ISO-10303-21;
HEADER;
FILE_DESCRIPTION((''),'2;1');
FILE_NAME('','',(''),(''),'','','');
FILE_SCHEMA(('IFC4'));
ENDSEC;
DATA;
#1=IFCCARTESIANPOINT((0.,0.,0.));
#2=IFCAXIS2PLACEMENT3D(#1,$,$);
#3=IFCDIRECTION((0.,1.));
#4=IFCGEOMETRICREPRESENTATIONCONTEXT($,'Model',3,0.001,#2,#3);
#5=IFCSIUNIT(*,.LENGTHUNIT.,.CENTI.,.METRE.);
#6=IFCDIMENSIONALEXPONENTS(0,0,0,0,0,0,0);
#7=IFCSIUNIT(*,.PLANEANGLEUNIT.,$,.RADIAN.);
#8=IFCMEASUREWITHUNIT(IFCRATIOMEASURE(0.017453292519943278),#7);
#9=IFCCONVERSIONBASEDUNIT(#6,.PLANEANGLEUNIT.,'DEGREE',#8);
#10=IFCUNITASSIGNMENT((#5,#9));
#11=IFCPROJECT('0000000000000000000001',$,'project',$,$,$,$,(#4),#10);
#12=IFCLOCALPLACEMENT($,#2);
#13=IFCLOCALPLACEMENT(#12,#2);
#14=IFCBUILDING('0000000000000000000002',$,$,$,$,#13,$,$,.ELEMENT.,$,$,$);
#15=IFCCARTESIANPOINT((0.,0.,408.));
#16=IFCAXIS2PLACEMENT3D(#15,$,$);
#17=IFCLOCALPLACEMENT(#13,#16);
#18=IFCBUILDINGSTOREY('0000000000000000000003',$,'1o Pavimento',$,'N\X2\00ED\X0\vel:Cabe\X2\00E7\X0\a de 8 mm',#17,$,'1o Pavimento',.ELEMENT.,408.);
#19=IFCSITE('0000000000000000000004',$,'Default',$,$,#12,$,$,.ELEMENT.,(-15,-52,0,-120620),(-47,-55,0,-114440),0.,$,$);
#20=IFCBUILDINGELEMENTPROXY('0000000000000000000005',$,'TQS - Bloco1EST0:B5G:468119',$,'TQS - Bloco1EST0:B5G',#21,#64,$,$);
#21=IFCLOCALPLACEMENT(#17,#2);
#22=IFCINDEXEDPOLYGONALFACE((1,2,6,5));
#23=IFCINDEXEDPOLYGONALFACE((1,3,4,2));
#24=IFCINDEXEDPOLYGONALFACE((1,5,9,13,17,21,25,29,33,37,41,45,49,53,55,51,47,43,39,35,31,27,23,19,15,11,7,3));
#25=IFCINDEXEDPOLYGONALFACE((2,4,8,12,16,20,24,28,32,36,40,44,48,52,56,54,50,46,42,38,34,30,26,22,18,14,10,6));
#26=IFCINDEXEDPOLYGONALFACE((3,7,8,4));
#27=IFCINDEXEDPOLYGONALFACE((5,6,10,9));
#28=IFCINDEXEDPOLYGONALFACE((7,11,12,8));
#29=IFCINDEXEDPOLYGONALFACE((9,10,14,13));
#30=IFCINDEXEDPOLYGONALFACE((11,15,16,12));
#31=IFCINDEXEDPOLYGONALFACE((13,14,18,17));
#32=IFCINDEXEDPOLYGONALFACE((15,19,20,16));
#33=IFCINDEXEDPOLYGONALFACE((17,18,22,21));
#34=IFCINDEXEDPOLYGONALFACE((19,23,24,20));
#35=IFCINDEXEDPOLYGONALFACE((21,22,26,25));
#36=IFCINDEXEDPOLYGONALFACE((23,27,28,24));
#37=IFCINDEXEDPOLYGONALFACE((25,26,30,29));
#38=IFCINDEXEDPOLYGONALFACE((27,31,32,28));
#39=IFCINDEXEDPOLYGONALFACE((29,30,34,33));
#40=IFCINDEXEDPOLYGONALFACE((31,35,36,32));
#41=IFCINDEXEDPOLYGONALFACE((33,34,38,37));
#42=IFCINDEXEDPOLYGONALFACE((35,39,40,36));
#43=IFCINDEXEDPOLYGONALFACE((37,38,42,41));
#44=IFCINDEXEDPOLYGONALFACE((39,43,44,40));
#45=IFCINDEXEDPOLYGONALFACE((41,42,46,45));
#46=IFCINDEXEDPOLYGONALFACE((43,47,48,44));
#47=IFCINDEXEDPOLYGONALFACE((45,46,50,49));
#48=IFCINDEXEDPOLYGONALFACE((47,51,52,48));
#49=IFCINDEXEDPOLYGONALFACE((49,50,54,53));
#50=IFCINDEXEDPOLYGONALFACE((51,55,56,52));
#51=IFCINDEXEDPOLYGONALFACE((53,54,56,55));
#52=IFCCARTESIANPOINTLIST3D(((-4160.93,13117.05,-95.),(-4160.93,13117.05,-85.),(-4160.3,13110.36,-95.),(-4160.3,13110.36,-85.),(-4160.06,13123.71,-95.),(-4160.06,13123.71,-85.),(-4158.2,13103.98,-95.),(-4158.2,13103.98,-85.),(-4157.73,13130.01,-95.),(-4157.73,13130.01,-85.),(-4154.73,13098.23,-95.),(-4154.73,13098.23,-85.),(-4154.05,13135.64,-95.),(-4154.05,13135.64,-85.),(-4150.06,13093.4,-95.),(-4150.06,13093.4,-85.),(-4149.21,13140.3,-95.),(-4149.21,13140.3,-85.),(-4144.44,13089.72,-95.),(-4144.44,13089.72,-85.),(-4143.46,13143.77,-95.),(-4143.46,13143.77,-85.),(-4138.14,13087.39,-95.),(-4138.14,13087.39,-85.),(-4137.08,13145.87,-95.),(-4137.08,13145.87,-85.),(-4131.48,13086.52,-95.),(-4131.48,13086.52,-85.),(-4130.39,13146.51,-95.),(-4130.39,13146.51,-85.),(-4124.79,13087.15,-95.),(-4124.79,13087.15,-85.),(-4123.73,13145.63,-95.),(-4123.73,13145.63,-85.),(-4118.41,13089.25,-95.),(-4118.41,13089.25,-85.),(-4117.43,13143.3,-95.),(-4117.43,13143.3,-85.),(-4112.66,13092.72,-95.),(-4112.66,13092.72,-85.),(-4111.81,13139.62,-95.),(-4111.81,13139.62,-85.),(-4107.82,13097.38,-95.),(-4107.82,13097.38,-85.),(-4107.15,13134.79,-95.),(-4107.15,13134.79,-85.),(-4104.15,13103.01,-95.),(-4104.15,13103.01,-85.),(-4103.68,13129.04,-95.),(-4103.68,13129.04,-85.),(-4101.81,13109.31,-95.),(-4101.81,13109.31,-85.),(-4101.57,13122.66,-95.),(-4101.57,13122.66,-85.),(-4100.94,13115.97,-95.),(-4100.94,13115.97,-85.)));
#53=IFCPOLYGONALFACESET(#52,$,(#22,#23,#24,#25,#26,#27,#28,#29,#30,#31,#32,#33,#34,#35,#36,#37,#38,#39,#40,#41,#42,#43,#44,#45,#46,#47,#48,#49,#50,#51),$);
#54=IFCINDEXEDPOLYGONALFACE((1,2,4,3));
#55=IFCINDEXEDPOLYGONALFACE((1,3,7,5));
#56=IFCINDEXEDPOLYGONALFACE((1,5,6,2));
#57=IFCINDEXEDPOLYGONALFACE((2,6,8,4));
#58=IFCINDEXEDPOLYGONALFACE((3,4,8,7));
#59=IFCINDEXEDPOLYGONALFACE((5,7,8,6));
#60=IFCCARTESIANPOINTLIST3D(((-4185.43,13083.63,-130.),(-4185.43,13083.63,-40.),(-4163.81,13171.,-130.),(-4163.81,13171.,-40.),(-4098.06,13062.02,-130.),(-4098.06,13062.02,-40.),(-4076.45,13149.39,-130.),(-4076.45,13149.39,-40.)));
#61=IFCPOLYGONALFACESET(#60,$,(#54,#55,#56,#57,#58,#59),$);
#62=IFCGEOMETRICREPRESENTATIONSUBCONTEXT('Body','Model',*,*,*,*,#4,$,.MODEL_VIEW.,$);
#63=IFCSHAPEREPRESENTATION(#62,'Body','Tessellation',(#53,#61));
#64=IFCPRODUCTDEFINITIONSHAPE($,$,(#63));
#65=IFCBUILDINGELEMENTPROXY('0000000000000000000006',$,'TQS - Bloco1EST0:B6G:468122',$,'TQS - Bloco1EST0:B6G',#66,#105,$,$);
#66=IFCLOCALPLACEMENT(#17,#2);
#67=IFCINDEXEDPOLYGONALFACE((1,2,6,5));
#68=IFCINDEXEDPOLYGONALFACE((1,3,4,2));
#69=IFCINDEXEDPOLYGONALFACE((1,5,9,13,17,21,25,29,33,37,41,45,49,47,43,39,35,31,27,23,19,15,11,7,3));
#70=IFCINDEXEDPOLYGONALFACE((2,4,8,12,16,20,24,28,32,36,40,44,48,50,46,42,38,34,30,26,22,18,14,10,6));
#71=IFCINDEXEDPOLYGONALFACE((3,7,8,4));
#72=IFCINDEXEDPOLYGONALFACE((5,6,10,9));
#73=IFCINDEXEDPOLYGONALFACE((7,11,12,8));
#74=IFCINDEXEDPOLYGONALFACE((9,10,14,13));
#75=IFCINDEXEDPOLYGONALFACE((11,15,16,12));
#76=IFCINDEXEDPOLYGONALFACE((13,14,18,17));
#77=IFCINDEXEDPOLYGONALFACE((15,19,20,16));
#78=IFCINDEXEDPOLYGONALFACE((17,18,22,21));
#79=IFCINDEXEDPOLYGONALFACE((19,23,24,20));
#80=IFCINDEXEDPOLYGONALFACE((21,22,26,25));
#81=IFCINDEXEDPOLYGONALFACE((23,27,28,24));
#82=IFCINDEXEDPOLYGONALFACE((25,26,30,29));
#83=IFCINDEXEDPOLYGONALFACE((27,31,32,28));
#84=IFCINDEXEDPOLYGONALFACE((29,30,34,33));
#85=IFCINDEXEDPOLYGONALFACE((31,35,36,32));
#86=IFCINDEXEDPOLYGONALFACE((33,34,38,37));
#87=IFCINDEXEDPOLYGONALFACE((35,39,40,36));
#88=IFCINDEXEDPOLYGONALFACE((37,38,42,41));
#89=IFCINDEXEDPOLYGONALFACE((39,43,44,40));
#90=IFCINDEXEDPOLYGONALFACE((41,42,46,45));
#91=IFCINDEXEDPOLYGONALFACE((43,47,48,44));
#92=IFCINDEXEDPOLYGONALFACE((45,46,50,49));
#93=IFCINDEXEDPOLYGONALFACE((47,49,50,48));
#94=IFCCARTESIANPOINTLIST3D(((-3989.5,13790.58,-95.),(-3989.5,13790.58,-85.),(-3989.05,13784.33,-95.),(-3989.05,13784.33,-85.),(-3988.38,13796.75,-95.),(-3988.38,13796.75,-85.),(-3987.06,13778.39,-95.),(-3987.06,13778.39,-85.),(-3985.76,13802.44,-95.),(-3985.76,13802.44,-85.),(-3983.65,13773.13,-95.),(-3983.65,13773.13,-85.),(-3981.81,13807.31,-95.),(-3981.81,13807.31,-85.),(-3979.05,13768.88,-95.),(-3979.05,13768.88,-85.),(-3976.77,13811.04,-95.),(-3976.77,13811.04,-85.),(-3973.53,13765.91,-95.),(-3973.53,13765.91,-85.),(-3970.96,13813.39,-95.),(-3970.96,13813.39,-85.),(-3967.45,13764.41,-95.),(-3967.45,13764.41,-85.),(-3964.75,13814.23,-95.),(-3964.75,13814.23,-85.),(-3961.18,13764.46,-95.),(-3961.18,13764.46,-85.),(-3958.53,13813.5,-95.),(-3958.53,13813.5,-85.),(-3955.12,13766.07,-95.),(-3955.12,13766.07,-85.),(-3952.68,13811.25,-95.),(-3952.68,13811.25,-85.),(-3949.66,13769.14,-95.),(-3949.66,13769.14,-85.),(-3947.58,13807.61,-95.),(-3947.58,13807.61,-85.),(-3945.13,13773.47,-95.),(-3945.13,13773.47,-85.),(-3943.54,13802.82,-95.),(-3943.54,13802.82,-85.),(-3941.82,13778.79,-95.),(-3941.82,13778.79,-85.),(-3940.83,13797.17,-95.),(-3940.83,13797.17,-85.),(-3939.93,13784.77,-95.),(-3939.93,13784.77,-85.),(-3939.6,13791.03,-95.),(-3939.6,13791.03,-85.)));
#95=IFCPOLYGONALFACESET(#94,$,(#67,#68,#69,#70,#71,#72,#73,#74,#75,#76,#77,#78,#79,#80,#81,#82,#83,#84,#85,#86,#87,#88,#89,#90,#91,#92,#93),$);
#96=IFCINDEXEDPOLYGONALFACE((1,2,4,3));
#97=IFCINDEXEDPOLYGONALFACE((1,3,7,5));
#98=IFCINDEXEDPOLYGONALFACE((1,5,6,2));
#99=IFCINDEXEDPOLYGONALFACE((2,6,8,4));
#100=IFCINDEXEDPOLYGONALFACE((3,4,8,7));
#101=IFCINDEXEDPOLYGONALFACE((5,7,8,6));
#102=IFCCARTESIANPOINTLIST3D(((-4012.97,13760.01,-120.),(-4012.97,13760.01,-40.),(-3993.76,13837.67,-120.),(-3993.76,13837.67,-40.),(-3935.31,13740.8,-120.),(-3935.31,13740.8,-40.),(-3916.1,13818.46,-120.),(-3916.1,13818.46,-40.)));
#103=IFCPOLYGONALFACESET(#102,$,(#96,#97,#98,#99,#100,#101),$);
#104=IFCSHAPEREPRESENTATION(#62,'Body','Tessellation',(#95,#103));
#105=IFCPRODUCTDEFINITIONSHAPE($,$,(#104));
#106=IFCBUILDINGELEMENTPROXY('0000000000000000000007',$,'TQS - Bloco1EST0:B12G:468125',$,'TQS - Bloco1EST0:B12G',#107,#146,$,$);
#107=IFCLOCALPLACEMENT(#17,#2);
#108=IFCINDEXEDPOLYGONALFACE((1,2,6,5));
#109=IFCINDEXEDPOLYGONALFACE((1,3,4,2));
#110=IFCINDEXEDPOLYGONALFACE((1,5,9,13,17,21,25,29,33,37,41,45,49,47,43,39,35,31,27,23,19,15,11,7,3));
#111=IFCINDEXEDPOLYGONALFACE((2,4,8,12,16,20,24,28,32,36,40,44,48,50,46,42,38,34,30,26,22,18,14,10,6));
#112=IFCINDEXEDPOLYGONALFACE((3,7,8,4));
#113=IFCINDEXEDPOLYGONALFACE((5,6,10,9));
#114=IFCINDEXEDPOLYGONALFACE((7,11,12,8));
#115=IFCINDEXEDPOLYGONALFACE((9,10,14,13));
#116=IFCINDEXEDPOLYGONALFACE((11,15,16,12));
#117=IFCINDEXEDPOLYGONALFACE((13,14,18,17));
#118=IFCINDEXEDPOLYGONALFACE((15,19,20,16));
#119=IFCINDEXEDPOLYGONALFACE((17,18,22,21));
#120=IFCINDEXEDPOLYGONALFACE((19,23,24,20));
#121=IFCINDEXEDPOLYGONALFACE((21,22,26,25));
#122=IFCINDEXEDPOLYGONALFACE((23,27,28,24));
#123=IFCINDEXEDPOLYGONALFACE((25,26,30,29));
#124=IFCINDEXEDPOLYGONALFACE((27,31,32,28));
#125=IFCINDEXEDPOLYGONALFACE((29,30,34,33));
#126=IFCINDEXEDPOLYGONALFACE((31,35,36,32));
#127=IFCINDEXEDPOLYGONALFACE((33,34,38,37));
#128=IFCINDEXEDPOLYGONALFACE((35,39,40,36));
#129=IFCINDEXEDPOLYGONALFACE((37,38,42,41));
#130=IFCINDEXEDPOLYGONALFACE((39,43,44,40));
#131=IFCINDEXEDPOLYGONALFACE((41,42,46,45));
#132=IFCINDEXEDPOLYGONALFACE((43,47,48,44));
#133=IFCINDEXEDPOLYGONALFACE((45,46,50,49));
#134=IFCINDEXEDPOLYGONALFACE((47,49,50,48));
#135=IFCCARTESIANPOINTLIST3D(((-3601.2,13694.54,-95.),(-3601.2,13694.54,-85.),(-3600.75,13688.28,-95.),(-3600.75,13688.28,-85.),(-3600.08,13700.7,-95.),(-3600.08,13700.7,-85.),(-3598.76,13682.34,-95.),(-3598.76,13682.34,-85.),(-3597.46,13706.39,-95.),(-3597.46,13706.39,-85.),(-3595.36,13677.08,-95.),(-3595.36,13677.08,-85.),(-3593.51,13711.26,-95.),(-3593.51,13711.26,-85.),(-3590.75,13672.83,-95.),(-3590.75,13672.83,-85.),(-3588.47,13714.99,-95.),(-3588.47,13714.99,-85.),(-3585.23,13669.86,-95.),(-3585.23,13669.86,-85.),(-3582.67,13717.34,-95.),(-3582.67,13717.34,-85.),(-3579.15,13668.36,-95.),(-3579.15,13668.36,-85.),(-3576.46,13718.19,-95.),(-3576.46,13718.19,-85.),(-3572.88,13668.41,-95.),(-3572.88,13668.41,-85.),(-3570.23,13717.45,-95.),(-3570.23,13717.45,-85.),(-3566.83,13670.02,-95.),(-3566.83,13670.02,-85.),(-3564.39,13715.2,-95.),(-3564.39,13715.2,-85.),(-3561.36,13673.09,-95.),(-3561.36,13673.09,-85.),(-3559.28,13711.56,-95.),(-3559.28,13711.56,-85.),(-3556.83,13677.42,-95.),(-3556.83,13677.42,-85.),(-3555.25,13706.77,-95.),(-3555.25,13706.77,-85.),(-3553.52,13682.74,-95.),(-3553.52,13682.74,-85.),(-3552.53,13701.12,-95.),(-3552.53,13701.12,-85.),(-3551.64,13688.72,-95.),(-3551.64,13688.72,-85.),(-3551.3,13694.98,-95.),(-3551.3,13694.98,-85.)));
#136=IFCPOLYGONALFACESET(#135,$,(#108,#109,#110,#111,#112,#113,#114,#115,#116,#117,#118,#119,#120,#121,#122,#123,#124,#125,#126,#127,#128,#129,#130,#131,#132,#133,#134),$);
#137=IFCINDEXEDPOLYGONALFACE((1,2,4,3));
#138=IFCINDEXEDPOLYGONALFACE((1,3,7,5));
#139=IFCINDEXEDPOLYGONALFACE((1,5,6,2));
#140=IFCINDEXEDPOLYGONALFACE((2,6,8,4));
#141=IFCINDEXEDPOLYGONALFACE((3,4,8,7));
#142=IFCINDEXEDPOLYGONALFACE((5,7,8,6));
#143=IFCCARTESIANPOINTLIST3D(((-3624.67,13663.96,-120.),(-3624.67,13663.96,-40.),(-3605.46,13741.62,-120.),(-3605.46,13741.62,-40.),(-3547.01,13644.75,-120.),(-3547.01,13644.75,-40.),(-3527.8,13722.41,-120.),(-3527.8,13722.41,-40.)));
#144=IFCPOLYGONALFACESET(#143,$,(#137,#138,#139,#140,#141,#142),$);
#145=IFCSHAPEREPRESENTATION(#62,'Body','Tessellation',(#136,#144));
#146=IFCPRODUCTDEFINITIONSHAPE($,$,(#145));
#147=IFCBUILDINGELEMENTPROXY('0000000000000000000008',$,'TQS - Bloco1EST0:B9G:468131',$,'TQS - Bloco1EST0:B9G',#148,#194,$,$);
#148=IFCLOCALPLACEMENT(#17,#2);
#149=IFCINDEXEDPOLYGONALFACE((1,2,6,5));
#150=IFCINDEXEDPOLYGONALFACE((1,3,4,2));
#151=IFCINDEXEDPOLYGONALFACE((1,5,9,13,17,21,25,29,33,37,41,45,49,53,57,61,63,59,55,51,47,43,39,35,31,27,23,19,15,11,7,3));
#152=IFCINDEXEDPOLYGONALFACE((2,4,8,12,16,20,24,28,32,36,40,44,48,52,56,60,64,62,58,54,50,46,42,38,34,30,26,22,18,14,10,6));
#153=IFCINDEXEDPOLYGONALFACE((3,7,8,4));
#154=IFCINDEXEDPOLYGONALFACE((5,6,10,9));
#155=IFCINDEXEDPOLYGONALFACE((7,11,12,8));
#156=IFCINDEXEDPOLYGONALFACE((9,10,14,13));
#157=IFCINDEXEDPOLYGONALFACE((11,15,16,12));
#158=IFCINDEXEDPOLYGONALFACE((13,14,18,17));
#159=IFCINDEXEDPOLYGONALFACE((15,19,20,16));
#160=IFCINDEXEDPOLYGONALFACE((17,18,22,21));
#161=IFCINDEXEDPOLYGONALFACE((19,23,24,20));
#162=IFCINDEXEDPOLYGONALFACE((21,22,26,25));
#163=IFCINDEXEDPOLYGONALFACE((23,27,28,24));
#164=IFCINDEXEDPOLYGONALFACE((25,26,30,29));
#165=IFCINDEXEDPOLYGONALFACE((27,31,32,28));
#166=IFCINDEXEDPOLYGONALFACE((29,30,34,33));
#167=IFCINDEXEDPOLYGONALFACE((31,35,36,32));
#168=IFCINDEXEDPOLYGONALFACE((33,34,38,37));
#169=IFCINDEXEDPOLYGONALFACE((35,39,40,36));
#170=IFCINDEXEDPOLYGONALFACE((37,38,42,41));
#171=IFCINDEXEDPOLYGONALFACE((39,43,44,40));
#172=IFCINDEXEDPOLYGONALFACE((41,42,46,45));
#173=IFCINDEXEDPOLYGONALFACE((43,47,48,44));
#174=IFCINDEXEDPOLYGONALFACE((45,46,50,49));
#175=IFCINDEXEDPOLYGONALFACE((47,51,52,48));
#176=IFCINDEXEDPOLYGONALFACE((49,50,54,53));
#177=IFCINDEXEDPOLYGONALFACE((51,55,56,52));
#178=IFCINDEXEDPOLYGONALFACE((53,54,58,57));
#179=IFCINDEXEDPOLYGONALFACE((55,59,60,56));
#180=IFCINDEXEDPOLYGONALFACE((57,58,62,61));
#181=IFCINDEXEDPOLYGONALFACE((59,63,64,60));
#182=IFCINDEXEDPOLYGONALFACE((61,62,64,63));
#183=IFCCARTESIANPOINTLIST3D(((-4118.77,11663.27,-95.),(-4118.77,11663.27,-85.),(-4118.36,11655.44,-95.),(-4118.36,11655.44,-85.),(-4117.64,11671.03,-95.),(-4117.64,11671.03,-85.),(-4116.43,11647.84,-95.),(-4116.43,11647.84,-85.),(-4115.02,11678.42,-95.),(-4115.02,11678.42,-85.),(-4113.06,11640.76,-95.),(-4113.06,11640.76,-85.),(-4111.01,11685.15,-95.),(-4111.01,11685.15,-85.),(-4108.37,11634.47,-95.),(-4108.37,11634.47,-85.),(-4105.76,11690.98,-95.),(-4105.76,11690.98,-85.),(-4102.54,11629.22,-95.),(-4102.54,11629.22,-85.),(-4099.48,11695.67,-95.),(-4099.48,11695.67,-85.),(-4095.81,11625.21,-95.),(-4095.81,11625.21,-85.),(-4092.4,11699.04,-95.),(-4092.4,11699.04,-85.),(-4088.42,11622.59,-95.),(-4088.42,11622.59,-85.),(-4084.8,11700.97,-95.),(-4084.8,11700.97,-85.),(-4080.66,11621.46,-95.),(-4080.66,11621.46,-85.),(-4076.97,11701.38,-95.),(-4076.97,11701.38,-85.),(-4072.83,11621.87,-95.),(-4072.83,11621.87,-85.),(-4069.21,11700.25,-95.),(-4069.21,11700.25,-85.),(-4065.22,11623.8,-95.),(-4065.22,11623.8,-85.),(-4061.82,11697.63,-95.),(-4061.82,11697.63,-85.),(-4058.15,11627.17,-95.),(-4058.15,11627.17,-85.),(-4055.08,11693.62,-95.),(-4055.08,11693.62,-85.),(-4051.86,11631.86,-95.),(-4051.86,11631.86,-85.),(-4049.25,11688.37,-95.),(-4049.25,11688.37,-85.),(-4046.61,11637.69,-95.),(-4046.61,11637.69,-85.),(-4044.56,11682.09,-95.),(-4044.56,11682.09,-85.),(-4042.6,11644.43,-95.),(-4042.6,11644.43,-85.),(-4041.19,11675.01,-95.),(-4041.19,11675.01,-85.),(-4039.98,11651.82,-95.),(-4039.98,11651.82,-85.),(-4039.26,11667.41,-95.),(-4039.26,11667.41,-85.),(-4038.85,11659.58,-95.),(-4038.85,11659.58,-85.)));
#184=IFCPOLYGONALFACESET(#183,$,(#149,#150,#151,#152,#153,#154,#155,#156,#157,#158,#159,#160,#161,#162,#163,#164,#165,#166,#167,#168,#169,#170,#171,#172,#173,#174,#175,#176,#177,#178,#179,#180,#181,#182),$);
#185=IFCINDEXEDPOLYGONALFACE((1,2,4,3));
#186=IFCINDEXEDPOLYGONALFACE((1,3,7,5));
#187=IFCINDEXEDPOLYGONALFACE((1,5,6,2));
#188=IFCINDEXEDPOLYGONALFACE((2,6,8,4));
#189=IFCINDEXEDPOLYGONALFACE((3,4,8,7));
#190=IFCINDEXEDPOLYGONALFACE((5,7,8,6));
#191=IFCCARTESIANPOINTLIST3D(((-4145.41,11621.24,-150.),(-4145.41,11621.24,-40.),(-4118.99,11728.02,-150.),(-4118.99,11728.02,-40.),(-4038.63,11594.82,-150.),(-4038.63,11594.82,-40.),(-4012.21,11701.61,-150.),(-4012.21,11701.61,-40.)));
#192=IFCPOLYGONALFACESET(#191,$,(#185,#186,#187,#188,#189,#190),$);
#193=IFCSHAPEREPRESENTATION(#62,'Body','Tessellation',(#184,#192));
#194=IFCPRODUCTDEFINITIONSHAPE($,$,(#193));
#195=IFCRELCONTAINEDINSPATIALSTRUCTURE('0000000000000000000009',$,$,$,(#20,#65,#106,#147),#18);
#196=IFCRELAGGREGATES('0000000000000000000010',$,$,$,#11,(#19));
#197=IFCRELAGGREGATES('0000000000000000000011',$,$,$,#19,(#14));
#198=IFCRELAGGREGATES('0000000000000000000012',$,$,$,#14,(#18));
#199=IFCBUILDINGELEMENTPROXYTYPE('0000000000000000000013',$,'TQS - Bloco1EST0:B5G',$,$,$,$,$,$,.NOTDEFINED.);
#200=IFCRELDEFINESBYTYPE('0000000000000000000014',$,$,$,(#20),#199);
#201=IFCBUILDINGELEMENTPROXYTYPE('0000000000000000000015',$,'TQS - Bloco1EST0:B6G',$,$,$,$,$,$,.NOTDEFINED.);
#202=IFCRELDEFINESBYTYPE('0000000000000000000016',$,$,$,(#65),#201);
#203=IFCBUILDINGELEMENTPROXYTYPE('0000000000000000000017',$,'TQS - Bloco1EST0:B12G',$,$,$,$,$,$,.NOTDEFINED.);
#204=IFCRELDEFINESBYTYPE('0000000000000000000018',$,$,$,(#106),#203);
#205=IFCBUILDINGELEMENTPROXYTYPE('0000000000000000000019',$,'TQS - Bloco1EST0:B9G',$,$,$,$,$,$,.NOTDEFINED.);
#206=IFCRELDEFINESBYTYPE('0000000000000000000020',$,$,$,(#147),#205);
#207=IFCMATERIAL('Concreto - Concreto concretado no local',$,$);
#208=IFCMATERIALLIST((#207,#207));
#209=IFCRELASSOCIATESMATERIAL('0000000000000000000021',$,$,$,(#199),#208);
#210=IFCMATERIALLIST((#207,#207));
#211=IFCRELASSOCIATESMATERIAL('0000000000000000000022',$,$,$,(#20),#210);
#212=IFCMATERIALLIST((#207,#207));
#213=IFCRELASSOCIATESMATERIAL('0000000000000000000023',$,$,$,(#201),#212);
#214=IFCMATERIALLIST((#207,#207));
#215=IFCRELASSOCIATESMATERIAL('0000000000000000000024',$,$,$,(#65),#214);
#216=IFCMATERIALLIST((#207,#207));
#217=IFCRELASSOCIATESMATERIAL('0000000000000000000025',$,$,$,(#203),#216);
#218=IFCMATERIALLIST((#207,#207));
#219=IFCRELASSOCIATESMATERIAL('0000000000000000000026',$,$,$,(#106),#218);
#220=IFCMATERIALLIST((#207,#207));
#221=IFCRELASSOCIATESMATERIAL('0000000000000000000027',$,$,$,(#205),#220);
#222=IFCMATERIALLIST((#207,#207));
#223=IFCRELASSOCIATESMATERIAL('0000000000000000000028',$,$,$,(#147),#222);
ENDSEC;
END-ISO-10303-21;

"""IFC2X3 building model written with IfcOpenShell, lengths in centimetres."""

from ifc_helpers import new_model, entity, si_unit, converted_unit, direction, frame, frame_2d, origin, origin_2d_with_axis, place, context, subcontext, project, spatial, rectangle, circle, extrude, source, transform, mapped, material, material_list, type_object, type_shapes, element, save


model = new_model("IFC2X3")

# Units and contexts
model_context = context("Model", 3, precision=0.001, world=origin(), true_north=direction((0.0, 1.0)))
body_context = subcontext(model_context, "Body", "Model", "MODEL_VIEW")
ifc_project = project(units=[si_unit("LENGTHUNIT", "METRE", prefix="CENTI"), converted_unit("PLANEANGLEUNIT", "DEGREE", entity("IfcRatioMeasure", 0.017453292519943278), si_unit("PLANEANGLEUNIT", "RADIAN"), dimensions=[0, 0, 0, 0, 0, 0, 0])], contexts=[model_context])

# Site, building, storey
site_placement = place(None, origin())
site = spatial("IfcSite", under=ifc_project, at=site_placement, Name="Default", CompositionType="ELEMENT", RefLatitude=(-15, -52, 0, -120620), RefLongitude=(-47, -55, 0, -114440), RefElevation=0.0)
building_placement = place(site_placement, origin())
building = spatial("IfcBuilding", under=site, at=building_placement, CompositionType="ELEMENT")
storey_placement = place(building_placement, frame((0.0, 0.0, 408.0)))
storey = spatial("IfcBuildingStorey", under=building, at=storey_placement, Name="1o Pavimento", ObjectType="Nível:Cabeça de 8 mm", LongName="1o Pavimento", CompositionType="ELEMENT", Elevation=408.0)

# Building element proxies
ifc_material_1 = material(Name="Concreto - Concreto concretado no local")
ifc_material_list_1 = material_list([ifc_material_1, ifc_material_1])
ifc_material_list_2 = material_list([ifc_material_1, ifc_material_1])
building_element_proxy_type_1 = type_object("IfcBuildingElementProxyType", Name="TQS - Bloco1EST0:B5G", PredefinedType="NOTDEFINED", material=ifc_material_list_2)
shared_shape_1 = source(origin(), body_context, "Body", "SweptSolid", [
    extrude(circle(Radius=30.0, at=frame_2d((0.0, 0.0), x_axis=(1.0, 0.0))), frame((0.0, 0.0, -55.0)), (0.0, 0.0, 1.0), 10.0),
    extrude(rectangle(XDim=90.0, YDim=90.0, at=origin_2d_with_axis()), frame((0.0, 0.0, -90.0), z_axis=(0.0, 0.0, 1.0), x_axis=(-1.0, 0.0, 0.0)), (0.0, 0.0, 1.0), 90.0),
])
type_shapes(building_element_proxy_type_1, [shared_shape_1])
proxy_1_placement = place(storey_placement, frame((-4130.94, 13116.51, -40.0), z_axis=(0.0, 0.0, 1.0), x_axis=(0.240122, 0.970743, 0.0)))
element("IfcBuildingElementProxy", 1, at=proxy_1_placement, inside=storey, type_object=building_element_proxy_type_1, material=ifc_material_list_1, Name="TQS - Bloco1EST0:B5G:468119", ObjectType="TQS - Bloco1EST0:B5G", context=body_context, shape_type="MappedRepresentation", body=[
    mapped(shared_shape_1, transform((0.0, 0.0, 0.0), scale=1.0)),
])
ifc_material_list_3 = material_list([ifc_material_1, ifc_material_1])
ifc_material_list_4 = material_list([ifc_material_1, ifc_material_1])
building_element_proxy_type_2 = type_object("IfcBuildingElementProxyType", Name="TQS - Bloco1EST0:B6G", PredefinedType="NOTDEFINED", material=ifc_material_list_4)
shared_shape_2 = source(origin(), body_context, "Body", "SweptSolid", [
    extrude(circle(Radius=25.0, at=frame_2d((0.0, 0.0), x_axis=(1.0, 0.0))), frame((0.0, 0.0, -55.0)), (0.0, 0.0, 1.0), 10.0),
    extrude(rectangle(XDim=80.0, YDim=80.0, at=origin_2d_with_axis()), frame((0.0, 0.0, -80.0), z_axis=(0.0, 0.0, 1.0), x_axis=(-1.0, 0.0, 0.0)), (0.0, 0.0, 1.0), 80.0),
])
type_shapes(building_element_proxy_type_2, [shared_shape_2])
proxy_2_placement = place(storey_placement, frame((-3964.53, 13789.23, -40.0), z_axis=(0.0, 0.0, 1.0), x_axis=(0.240122, 0.970743, 0.0)))
element("IfcBuildingElementProxy", 2, at=proxy_2_placement, inside=storey, type_object=building_element_proxy_type_2, material=ifc_material_list_3, Name="TQS - Bloco1EST0:B6G:468122", ObjectType="TQS - Bloco1EST0:B6G", context=body_context, shape_type="MappedRepresentation", body=[
    mapped(shared_shape_2, transform((0.0, 0.0, 0.0), scale=1.0)),
])
ifc_material_list_5 = material_list([ifc_material_1, ifc_material_1])
ifc_material_list_6 = material_list([ifc_material_1, ifc_material_1])
building_element_proxy_type_3 = type_object("IfcBuildingElementProxyType", Name="TQS - Bloco1EST0:B12G", PredefinedType="NOTDEFINED", material=ifc_material_list_6)
shared_shape_3 = source(origin(), body_context, "Body", "SweptSolid", [
    extrude(circle(Radius=25.0, at=frame_2d((0.0, 0.0), x_axis=(1.0, 0.0))), frame((0.0, 0.0, -55.0)), (0.0, 0.0, 1.0), 10.0),
    extrude(rectangle(XDim=80.0, YDim=80.0, at=origin_2d_with_axis()), frame((0.0, 0.0, -80.0), z_axis=(0.0, 0.0, 1.0), x_axis=(-1.0, 0.0, 0.0)), (0.0, 0.0, 1.0), 80.0),
])
type_shapes(building_element_proxy_type_3, [shared_shape_3])
proxy_3_placement = place(storey_placement, frame((-3576.24, 13693.19, -40.0), z_axis=(0.0, 0.0, 1.0), x_axis=(0.240122, 0.970743, 0.0)))
element("IfcBuildingElementProxy", 3, at=proxy_3_placement, inside=storey, type_object=building_element_proxy_type_3, material=ifc_material_list_5, Name="TQS - Bloco1EST0:B12G:468125", ObjectType="TQS - Bloco1EST0:B12G", context=body_context, shape_type="MappedRepresentation", body=[
    mapped(shared_shape_3, transform((0.0, 0.0, 0.0), scale=1.0)),
])
ifc_material_list_7 = material_list([ifc_material_1, ifc_material_1])
ifc_material_list_8 = material_list([ifc_material_1, ifc_material_1])
building_element_proxy_type_4 = type_object("IfcBuildingElementProxyType", Name="TQS - Bloco1EST0:B9G", PredefinedType="NOTDEFINED", material=ifc_material_list_8)
shared_shape_4 = source(origin(), body_context, "Body", "SweptSolid", [
    extrude(circle(Radius=40.0, at=frame_2d((0.0, 0.0), x_axis=(1.0, 0.0))), frame((0.0, 0.0, -55.0)), (0.0, 0.0, 1.0), 10.0),
    extrude(rectangle(XDim=110.0, YDim=110.0, at=origin_2d_with_axis()), frame((0.0, 0.0, -110.0), z_axis=(0.0, 0.0, 1.0), x_axis=(-1.0, 0.0, 0.0)), (0.0, 0.0, 1.0), 110.0),
])
type_shapes(building_element_proxy_type_4, [shared_shape_4])
proxy_4_placement = place(storey_placement, frame((-4078.81, 11661.42, -40.0), z_axis=(0.0, 0.0, 1.0), x_axis=(0.240122, 0.970743, 0.0)))
element("IfcBuildingElementProxy", 4, at=proxy_4_placement, inside=storey, type_object=building_element_proxy_type_4, material=ifc_material_list_7, Name="TQS - Bloco1EST0:B9G:468131", ObjectType="TQS - Bloco1EST0:B9G", context=body_context, shape_type="MappedRepresentation", body=[
    mapped(shared_shape_4, transform((0.0, 0.0, 0.0), scale=1.0)),
])

save(model, "model.ifc")
